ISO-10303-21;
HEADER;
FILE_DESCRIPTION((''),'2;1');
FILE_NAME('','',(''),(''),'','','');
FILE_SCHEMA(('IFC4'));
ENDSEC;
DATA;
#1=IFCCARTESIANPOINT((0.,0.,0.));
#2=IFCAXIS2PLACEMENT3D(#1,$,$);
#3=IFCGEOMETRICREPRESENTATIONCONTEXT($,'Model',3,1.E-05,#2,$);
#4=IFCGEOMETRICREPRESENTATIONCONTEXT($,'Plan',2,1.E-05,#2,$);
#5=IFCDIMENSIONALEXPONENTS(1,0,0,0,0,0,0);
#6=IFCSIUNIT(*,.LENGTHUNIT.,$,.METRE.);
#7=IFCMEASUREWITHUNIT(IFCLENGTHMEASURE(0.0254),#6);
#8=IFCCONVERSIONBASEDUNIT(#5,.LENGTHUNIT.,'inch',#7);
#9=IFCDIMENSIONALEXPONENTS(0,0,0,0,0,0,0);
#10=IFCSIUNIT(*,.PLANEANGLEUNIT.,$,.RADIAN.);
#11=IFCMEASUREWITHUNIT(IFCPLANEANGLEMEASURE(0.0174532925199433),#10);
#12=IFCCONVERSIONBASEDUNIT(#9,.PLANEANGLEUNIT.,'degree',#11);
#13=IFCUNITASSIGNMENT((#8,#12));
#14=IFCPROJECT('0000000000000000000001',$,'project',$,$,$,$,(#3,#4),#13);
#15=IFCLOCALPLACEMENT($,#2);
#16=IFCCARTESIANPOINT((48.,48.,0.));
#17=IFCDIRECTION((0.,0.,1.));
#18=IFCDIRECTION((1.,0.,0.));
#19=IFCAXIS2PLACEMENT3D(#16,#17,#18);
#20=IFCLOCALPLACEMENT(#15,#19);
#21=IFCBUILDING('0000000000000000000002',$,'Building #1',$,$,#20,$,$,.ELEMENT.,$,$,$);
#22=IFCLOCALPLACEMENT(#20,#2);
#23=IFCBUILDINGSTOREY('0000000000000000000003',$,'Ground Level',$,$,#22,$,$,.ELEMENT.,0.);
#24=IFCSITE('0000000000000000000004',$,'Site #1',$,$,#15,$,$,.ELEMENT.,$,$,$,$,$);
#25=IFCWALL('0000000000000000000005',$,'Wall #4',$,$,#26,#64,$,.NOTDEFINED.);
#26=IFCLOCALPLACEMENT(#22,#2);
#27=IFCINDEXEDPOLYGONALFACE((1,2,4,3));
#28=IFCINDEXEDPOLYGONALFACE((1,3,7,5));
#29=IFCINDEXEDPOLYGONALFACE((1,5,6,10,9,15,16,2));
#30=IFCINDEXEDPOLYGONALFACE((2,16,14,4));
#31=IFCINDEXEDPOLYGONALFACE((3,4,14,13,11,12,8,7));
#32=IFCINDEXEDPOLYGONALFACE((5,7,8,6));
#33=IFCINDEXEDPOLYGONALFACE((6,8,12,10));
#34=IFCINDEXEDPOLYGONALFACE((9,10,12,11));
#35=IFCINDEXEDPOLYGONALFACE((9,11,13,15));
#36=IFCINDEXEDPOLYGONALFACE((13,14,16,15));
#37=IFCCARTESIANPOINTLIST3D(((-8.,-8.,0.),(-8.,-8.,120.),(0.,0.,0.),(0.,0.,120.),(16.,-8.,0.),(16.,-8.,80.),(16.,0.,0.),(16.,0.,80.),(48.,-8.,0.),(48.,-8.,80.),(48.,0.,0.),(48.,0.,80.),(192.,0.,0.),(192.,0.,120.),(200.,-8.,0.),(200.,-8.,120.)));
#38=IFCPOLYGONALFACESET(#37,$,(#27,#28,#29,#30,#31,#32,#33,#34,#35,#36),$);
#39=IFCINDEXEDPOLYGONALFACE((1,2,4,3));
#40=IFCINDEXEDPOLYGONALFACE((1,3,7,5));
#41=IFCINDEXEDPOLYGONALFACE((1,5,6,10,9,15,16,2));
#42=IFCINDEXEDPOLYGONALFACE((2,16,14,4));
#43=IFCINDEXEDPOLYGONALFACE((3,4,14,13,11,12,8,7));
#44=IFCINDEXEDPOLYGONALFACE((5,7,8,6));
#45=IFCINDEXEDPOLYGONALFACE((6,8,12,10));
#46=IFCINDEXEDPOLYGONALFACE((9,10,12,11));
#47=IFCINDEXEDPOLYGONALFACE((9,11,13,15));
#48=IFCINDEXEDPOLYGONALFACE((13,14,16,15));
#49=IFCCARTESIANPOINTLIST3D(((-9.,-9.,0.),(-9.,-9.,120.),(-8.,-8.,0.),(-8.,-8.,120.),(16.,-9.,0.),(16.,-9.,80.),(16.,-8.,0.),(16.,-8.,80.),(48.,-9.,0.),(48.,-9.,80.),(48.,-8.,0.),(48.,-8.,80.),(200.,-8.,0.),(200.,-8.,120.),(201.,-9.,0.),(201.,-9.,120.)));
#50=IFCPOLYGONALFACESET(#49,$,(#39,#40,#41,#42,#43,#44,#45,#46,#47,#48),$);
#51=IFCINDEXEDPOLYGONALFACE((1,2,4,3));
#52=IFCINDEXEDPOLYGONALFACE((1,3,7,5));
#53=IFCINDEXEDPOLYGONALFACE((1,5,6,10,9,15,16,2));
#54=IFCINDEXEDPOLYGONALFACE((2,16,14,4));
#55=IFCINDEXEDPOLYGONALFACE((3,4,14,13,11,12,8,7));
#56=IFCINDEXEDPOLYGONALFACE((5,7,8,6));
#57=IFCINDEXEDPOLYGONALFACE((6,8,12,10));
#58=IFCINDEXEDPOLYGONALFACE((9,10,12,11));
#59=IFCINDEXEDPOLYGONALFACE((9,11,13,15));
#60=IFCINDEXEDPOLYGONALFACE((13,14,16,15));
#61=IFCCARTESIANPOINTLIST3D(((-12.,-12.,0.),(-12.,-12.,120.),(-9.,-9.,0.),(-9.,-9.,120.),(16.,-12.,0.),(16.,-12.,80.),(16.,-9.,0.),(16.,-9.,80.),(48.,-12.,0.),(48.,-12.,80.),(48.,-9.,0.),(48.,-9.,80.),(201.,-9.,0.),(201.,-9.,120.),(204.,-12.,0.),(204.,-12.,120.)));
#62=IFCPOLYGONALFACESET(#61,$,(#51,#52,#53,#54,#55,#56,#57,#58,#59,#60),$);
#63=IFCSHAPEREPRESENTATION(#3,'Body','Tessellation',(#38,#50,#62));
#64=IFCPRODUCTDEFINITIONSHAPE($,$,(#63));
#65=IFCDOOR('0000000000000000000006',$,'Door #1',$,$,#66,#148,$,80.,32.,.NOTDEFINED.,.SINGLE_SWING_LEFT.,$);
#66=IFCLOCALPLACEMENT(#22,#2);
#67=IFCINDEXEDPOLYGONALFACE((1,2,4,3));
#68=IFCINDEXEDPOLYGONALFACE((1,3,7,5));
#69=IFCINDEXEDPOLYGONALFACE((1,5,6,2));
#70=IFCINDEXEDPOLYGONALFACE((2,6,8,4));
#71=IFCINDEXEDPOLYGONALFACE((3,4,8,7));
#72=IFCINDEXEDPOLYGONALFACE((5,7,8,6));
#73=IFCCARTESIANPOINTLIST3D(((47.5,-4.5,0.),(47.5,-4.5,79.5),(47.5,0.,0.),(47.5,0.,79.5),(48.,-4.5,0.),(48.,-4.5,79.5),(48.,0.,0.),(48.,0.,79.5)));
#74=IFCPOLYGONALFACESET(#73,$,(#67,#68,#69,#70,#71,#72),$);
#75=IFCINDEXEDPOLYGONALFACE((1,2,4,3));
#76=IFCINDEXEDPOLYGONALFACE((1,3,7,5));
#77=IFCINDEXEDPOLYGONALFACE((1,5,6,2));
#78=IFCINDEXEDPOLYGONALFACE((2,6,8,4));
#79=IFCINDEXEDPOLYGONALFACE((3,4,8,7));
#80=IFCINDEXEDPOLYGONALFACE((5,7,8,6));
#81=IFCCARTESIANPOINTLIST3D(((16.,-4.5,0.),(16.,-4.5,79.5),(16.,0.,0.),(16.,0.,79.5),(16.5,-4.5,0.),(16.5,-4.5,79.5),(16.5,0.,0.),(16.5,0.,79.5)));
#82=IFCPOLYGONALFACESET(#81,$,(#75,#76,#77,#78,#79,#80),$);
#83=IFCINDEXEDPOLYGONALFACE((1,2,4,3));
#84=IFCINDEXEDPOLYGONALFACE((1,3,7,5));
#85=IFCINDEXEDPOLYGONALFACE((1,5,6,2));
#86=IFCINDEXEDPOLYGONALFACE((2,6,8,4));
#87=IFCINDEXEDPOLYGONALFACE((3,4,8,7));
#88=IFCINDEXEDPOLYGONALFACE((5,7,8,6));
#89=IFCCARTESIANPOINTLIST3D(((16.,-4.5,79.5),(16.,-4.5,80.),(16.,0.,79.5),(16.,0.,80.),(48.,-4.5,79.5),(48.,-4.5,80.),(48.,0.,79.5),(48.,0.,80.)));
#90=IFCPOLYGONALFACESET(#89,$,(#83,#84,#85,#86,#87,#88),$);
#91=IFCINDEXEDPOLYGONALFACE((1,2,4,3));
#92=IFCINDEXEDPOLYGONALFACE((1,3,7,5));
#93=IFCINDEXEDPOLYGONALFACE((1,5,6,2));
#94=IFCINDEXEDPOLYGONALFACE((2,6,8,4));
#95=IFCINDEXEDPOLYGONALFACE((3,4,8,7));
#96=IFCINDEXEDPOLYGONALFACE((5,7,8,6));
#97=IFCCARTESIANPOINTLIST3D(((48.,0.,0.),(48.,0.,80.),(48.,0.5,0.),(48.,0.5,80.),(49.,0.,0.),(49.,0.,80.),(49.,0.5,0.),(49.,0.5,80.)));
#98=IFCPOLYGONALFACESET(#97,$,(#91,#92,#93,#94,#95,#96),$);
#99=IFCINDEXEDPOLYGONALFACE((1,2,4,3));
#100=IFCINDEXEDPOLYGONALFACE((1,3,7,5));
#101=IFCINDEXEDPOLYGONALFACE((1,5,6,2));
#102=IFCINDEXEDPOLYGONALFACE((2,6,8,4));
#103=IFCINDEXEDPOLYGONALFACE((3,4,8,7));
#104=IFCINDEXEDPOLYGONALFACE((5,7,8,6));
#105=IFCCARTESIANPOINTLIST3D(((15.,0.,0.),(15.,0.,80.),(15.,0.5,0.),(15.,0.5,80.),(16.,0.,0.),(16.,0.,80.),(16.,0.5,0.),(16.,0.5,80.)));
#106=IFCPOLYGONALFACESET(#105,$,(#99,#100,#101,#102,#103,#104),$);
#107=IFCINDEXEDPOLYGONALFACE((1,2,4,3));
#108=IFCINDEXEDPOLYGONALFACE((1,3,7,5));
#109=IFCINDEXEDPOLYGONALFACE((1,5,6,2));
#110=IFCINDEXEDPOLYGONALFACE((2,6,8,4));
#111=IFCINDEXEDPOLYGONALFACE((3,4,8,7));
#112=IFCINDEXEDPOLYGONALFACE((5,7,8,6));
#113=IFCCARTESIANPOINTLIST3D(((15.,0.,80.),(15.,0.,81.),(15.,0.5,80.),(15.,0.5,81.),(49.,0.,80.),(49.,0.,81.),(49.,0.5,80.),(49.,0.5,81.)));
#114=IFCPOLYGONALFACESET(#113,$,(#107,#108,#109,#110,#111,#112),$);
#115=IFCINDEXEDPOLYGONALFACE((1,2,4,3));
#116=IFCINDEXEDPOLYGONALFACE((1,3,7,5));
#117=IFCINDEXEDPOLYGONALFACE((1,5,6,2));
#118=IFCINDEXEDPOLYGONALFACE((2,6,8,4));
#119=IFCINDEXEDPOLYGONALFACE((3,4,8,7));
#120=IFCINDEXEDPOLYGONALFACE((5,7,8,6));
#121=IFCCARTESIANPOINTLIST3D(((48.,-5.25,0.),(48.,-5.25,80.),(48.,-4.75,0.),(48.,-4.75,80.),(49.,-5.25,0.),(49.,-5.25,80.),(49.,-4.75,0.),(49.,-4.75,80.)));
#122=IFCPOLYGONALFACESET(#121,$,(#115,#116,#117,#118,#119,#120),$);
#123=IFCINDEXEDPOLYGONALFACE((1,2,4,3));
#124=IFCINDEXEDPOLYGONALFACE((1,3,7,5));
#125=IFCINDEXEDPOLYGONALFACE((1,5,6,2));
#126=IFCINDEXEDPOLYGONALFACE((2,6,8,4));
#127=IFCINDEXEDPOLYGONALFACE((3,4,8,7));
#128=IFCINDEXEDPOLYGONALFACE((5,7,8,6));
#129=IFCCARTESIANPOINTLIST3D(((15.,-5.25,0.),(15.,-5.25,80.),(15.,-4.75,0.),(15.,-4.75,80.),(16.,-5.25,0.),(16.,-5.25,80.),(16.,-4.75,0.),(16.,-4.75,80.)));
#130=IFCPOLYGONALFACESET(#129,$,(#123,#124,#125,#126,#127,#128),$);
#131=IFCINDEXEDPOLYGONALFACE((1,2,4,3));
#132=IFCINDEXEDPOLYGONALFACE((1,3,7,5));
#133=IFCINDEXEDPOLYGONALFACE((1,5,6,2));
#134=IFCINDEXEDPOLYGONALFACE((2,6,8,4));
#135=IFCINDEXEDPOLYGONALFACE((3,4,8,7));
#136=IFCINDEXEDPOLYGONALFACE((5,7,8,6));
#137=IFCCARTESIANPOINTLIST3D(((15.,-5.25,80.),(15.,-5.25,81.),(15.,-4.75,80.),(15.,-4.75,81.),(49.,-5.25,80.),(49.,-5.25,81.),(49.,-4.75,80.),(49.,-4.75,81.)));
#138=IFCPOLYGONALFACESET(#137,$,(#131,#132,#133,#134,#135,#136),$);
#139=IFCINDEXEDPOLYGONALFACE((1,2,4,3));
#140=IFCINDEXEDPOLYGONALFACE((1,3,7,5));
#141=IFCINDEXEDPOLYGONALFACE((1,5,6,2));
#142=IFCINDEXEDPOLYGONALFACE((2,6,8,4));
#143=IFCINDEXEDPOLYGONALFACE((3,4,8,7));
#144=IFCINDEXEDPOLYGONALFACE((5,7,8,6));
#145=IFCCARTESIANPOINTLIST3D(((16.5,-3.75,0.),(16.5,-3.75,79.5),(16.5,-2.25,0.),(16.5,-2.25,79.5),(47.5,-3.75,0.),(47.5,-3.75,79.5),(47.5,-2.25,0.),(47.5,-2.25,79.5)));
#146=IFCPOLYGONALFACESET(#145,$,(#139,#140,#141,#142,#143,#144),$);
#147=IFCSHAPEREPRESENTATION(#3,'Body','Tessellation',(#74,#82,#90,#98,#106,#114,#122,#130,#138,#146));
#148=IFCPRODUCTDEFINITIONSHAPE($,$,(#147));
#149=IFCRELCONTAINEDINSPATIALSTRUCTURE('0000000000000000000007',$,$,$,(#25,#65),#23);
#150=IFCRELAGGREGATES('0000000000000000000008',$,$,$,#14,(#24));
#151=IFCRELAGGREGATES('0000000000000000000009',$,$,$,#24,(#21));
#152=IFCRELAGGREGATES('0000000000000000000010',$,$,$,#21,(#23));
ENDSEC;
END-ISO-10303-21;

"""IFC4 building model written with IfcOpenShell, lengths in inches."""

from ifc_helpers import new_model, entity, si_unit, converted_unit, frame, frame_2d, origin, place, context, project, spatial, polyline, rectangle, outline, extrude, element, fill, save


model = new_model("IFC4")

# Units and contexts
model_context = context("Model", 3, precision=1e-05, world=origin())
plan_context = context("Plan", 2, precision=1e-05, world=origin())
ifc_project = project(units=[converted_unit("LENGTHUNIT", "inch", entity("IfcLengthMeasure", 0.0254), si_unit("LENGTHUNIT", "METRE"), dimensions=[1, 0, 0, 0, 0, 0, 0]), converted_unit("PLANEANGLEUNIT", "degree", entity("IfcPlaneAngleMeasure", 0.0174532925199433), si_unit("PLANEANGLEUNIT", "RADIAN"), dimensions=[0, 0, 0, 0, 0, 0, 0])], contexts=[model_context, plan_context])

# Site, building, storey
site_placement = place(None, origin())
site = spatial("IfcSite", under=ifc_project, at=site_placement, Name="Site #1", CompositionType="ELEMENT")
building_placement = place(site_placement, frame((48.0, 48.0, 0.0), z_axis=(0.0, 0.0, 1.0), x_axis=(1.0, 0.0, 0.0)))
building = spatial("IfcBuilding", under=site, at=building_placement, Name="Building #1", CompositionType="ELEMENT")
storey_placement = place(building_placement, origin())
storey = spatial("IfcBuildingStorey", under=building, at=storey_placement, Name="Ground Level", CompositionType="ELEMENT", Elevation=0.0)

# Wall, opening, door
wall_1_placement = place(storey_placement, frame((192.0, 0.0, 0.0), z_axis=(0.0, 0.0, 1.0), x_axis=(-1.0, 0.0, 0.0)))
wall_1 = element("IfcWall", 1, at=wall_1_placement, inside=storey, Name="Wall #4", PredefinedType="NOTDEFINED", context=model_context, shape_type="SweptSolid", body=[
    extrude(outline(polyline([(0.0, 0.0), (192.0, 0.0), (200.0, 8.0), (-8.0, 8.0), (0.0, 0.0)])), origin(), (0.0, 0.0, 1.0), 120.0),
    extrude(outline(polyline([(-8.0, 8.0), (200.0, 8.0), (201.0, 9.0), (-9.0, 9.0), (-8.0, 8.0)])), origin(), (0.0, 0.0, 1.0), 120.0),
    extrude(outline(polyline([(-9.0, 9.0), (201.0, 9.0), (204.0, 12.0), (-12.0, 12.0), (-9.0, 9.0)])), origin(), (0.0, 0.0, 1.0), 120.0),
])
opening_placement = place(wall_1_placement, frame((144.0, 0.0, 0.0)))
opening = element("IfcOpeningElement", 2, at=opening_placement, cuts=wall_1, context=model_context, shape_type="SweptSolid", body=[
    extrude(rectangle(XDim=32.0, YDim=80.0, at=frame_2d((-16.0, 40.0))), frame((0.0, 0.0, 0.0), z_axis=(0.0, 1.0, 0.0), x_axis=(-1.0, 0.0, 0.0)), (0.0, 0.0, 1.0), 12.0),
])
door_placement = place(opening_placement, origin())
door = element("IfcDoor", 3, at=door_placement, inside=storey, Name="Door #1", OperationType="SINGLE_SWING_LEFT", OverallHeight=80.0, OverallWidth=32.0, PredefinedType="NOTDEFINED", context=model_context, shape_type="SweptSolid", body=[
    extrude(rectangle(XDim=0.5, YDim=4.5), frame((0.25, 2.25, 0.0), z_axis=(0.0, 0.0, 1.0), x_axis=(1.0, 0.0, 0.0)), (0.0, 0.0, 1.0), 79.5),
    extrude(rectangle(XDim=0.5, YDim=4.5), frame((31.75, 2.25, 0.0), z_axis=(0.0, 0.0, 1.0), x_axis=(1.0, 0.0, 0.0)), (0.0, 0.0, 1.0), 79.5),
    extrude(rectangle(XDim=0.5, YDim=4.5), frame((0.0, 2.25, 79.75), z_axis=(1.0, 0.0, 0.0), x_axis=(0.0, 0.0, 1.0)), (0.0, 0.0, 1.0), 32.0),
    extrude(rectangle(XDim=1.0, YDim=0.5), frame((-0.5, -0.25, 0.0), z_axis=(0.0, 0.0, 1.0), x_axis=(1.0, 0.0, 0.0)), (0.0, 0.0, 1.0), 80.0),
    extrude(rectangle(XDim=1.0, YDim=0.5), frame((32.5, -0.25, 0.0), z_axis=(0.0, 0.0, 1.0), x_axis=(1.0, 0.0, 0.0)), (0.0, 0.0, 1.0), 80.0),
    extrude(rectangle(XDim=1.0, YDim=0.5), frame((-1.0, -0.25, 80.5), z_axis=(1.0, 0.0, 0.0), x_axis=(0.0, 0.0, -1.0)), (0.0, 0.0, 1.0), 34.0),
    extrude(rectangle(XDim=1.0, YDim=0.5), frame((-0.5, 5.0, 0.0), z_axis=(0.0, 0.0, 1.0), x_axis=(1.0, 0.0, 0.0)), (0.0, 0.0, 1.0), 80.0),
    extrude(rectangle(XDim=1.0, YDim=0.5), frame((32.5, 5.0, 0.0), z_axis=(0.0, 0.0, 1.0), x_axis=(1.0, 0.0, 0.0)), (0.0, 0.0, 1.0), 80.0),
    extrude(rectangle(XDim=1.0, YDim=0.5), frame((-1.0, 5.0, 80.5), z_axis=(1.0, 0.0, 0.0), x_axis=(0.0, 0.0, -1.0)), (0.0, 0.0, 1.0), 34.0),
    extrude(rectangle(XDim=31.0, YDim=1.5), frame((16.0, 3.0, 0.0), z_axis=(0.0, 0.0, 1.0), x_axis=(1.0, 0.0, 0.0)), (0.0, 0.0, 1.0), 79.5),
])
fill(opening, door)

save(model, "model.ifc")
